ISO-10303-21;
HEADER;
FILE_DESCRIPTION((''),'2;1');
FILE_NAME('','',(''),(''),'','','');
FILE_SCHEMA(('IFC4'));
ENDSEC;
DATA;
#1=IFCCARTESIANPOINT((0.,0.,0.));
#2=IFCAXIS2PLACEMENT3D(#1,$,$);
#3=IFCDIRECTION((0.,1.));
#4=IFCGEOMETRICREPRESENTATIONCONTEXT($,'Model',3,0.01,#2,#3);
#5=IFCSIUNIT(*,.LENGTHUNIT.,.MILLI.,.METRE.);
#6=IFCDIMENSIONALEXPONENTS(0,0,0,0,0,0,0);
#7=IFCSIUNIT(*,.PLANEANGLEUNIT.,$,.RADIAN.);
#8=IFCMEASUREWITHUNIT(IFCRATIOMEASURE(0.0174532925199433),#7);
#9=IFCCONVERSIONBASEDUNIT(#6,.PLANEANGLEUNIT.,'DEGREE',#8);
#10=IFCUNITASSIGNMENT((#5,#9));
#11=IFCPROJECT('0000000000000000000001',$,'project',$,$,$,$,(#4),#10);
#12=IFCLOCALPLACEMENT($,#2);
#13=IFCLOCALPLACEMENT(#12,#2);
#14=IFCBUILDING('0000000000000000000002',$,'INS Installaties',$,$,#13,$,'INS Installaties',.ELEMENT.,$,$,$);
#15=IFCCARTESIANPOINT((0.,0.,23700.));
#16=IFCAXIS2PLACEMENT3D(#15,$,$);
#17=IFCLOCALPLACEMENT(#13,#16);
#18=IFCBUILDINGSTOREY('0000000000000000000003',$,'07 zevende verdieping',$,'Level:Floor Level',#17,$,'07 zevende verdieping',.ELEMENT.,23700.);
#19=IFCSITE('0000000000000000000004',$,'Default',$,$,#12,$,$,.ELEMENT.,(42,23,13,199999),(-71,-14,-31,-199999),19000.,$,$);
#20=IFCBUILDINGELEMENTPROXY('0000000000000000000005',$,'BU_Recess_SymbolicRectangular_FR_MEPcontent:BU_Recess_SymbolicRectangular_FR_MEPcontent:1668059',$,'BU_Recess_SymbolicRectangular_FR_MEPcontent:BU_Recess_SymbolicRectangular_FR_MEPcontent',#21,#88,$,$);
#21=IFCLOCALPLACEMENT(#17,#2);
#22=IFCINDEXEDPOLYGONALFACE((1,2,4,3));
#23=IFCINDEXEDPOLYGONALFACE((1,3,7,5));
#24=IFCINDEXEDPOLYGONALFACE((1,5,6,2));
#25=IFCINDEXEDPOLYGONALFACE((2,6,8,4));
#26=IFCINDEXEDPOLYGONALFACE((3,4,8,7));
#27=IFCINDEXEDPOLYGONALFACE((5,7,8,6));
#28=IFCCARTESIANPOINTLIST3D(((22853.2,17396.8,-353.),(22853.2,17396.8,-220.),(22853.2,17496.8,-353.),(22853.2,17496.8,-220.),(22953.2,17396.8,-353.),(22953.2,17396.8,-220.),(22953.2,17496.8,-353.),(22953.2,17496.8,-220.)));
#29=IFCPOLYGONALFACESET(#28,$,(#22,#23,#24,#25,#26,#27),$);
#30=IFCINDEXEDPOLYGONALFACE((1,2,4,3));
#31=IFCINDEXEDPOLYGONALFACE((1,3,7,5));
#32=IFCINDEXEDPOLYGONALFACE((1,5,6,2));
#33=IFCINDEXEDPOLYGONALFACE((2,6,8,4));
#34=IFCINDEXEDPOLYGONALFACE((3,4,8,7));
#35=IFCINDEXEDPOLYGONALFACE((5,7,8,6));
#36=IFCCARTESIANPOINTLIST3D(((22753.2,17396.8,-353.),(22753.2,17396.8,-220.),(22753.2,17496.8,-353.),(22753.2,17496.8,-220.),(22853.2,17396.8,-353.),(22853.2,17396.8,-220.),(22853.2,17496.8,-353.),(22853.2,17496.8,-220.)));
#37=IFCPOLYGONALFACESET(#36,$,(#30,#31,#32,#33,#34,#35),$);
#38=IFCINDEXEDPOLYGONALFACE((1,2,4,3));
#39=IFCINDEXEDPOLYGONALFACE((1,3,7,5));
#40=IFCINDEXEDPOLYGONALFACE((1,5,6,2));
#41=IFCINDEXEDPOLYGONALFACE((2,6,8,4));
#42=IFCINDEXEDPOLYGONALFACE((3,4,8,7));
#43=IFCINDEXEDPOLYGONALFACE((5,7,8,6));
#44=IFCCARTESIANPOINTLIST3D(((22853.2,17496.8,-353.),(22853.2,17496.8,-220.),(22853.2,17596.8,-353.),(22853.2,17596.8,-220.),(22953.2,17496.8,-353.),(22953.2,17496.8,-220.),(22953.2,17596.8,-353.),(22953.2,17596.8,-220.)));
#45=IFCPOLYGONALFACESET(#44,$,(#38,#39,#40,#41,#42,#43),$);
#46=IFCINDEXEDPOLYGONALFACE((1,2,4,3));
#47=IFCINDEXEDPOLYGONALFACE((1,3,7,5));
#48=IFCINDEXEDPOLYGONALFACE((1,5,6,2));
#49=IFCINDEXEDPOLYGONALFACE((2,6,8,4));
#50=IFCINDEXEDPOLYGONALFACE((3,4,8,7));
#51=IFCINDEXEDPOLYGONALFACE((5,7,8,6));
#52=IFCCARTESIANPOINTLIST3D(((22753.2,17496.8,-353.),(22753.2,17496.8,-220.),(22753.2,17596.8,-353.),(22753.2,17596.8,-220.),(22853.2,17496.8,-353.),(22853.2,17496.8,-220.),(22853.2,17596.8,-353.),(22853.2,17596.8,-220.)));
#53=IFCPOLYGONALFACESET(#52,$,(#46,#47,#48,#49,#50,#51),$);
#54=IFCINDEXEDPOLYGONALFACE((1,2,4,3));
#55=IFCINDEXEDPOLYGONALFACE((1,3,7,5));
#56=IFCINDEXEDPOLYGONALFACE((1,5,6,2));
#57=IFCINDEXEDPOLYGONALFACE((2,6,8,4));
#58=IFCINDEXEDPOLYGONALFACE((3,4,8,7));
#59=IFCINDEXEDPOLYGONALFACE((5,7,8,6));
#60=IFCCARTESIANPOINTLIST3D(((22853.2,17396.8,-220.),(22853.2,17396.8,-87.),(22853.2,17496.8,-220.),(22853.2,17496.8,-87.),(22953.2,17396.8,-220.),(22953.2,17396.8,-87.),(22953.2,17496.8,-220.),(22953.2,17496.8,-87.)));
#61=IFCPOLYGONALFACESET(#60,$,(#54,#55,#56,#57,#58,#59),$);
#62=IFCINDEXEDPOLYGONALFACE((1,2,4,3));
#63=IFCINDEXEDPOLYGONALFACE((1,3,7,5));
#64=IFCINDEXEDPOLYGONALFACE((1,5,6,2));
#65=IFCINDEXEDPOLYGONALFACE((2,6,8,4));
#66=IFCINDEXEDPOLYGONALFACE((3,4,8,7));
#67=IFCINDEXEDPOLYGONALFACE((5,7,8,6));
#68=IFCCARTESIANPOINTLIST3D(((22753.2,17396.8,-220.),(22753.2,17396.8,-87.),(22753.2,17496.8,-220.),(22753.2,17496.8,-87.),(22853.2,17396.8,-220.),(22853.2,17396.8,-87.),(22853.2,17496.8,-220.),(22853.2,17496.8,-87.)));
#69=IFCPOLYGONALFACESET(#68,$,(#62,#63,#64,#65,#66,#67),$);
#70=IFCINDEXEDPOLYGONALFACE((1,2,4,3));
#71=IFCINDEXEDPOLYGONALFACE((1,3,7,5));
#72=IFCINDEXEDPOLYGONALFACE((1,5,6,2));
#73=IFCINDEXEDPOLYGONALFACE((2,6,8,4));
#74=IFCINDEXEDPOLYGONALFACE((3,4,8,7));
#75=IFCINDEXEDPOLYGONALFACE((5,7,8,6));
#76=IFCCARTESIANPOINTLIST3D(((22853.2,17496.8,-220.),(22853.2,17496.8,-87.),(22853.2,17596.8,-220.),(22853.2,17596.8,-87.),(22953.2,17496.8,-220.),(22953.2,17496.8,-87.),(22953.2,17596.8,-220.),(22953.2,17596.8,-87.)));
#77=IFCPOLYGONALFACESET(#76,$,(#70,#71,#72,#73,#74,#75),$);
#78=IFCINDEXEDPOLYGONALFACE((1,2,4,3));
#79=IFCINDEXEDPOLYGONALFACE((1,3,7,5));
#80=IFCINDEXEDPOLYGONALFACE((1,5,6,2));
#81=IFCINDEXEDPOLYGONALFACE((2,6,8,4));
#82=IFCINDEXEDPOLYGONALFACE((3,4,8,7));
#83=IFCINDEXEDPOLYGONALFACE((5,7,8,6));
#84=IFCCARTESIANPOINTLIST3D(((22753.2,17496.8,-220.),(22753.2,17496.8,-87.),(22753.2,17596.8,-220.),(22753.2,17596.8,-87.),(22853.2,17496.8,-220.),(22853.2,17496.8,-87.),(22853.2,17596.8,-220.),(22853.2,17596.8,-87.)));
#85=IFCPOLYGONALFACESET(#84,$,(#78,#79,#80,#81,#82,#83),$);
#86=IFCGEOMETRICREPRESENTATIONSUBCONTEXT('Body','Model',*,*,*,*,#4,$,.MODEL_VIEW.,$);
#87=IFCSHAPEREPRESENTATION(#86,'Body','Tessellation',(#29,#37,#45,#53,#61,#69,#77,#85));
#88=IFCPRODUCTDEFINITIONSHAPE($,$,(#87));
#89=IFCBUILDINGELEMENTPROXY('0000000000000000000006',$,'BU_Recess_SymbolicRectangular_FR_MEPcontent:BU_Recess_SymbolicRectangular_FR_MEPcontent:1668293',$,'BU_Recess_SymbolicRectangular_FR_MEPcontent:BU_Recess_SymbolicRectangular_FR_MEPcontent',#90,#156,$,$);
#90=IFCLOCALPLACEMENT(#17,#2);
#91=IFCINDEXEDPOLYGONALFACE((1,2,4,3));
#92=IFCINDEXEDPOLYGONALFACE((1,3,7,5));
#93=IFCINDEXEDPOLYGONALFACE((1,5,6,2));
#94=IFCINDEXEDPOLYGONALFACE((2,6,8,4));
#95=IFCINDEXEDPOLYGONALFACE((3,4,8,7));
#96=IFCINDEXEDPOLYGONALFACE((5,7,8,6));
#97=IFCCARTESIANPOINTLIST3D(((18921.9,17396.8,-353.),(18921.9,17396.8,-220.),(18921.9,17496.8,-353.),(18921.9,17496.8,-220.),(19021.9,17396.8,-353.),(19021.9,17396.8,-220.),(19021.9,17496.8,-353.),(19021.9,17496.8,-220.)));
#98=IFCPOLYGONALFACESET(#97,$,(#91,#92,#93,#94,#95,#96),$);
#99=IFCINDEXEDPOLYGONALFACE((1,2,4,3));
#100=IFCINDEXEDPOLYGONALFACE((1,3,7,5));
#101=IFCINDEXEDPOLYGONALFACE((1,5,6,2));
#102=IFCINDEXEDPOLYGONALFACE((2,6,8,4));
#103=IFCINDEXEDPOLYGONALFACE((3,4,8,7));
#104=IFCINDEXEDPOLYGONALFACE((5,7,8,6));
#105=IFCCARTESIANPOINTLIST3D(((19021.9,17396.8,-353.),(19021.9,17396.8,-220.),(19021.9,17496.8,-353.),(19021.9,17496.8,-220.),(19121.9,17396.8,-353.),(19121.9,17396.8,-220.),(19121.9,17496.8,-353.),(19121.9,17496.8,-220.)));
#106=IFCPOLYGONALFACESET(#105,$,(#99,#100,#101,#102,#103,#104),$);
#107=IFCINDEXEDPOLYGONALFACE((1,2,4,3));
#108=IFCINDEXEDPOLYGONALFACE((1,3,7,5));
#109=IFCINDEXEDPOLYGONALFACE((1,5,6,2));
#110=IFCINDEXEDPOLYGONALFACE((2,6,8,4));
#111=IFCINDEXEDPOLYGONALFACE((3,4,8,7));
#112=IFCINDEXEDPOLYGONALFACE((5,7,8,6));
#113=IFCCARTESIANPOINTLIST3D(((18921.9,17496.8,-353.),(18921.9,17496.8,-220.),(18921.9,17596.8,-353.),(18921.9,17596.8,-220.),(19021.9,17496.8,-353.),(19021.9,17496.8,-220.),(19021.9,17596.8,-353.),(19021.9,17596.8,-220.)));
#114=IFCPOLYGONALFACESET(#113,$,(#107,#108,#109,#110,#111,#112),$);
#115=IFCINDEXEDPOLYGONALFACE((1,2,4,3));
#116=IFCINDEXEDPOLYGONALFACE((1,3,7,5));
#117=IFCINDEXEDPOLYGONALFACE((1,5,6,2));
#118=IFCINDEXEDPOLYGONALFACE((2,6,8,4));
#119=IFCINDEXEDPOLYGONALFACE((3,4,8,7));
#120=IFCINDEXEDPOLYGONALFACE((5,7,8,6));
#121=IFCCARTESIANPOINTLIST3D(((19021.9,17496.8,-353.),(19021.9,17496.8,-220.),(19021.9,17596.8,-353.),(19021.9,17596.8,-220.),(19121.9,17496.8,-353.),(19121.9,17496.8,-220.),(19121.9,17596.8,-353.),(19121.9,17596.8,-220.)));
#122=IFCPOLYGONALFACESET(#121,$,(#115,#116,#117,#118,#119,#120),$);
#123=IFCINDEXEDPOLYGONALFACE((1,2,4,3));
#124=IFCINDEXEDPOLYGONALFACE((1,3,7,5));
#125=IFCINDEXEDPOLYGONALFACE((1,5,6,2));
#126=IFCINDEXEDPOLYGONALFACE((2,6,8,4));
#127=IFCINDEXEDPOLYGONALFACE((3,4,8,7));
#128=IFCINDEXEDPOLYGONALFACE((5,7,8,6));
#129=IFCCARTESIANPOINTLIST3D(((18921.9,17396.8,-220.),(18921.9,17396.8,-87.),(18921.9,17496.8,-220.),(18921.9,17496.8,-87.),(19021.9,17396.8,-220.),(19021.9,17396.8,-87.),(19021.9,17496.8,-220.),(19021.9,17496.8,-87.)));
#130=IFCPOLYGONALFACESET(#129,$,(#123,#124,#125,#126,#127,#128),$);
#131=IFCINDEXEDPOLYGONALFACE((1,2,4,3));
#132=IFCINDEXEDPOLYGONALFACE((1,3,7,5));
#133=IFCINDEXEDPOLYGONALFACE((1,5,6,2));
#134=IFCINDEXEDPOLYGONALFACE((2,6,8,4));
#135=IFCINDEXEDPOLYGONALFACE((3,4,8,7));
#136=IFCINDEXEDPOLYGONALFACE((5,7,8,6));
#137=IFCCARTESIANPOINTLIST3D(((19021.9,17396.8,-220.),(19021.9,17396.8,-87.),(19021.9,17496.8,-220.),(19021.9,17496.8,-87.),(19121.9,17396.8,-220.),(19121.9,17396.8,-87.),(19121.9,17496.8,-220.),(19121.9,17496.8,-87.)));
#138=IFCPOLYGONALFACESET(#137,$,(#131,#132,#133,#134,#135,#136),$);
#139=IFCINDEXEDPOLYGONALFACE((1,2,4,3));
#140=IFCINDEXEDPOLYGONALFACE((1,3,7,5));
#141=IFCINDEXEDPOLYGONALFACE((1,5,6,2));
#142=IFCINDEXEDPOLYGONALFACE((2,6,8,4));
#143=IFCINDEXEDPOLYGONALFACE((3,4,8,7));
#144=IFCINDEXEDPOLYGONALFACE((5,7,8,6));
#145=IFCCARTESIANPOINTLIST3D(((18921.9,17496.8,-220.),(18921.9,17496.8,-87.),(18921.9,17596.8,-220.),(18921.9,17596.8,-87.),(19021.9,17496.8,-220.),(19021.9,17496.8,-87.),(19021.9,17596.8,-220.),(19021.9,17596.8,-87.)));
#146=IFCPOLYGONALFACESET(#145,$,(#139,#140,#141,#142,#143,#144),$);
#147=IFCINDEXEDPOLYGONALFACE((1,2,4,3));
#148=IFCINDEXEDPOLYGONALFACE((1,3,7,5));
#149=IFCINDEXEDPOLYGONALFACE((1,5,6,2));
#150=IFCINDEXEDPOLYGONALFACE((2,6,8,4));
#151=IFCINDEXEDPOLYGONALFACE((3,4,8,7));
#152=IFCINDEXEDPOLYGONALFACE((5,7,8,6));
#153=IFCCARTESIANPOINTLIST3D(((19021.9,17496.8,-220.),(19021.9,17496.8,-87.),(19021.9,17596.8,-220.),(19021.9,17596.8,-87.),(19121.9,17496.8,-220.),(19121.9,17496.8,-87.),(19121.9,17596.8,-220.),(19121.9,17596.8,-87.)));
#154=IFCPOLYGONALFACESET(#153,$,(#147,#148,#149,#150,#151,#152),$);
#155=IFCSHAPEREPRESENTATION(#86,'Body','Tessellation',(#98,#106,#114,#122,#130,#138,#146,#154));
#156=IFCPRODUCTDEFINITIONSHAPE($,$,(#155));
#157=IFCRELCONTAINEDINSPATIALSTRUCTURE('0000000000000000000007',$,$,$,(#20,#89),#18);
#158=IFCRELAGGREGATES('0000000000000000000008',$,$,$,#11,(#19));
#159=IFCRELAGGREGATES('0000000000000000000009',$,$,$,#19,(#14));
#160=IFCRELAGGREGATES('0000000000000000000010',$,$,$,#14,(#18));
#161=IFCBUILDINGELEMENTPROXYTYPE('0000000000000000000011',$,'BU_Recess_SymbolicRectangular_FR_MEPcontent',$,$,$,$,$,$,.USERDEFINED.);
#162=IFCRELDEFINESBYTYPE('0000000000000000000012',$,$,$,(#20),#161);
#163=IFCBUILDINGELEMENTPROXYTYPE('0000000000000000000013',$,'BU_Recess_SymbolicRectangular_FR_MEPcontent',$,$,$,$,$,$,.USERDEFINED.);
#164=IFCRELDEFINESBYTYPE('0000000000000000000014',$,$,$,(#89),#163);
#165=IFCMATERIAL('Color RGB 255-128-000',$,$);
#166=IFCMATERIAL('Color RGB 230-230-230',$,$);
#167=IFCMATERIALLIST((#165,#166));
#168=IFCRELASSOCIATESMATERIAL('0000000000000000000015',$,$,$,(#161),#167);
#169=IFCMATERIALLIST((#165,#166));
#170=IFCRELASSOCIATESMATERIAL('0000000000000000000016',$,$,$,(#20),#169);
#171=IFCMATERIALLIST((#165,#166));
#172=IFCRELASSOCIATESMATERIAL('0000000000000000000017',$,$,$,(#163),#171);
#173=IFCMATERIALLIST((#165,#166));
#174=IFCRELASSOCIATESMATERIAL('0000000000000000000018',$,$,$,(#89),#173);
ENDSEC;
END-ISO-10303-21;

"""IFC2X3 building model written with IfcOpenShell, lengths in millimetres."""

from ifc_helpers import new_model, entity, si_unit, converted_unit, direction, frame, frame_2d, origin, origin_2d_with_axis, place, context, subcontext, project, spatial, rectangle, extrude, source, transform, mapped, material, material_list, type_object, type_shapes, element, save


model = new_model("IFC2X3")

# Units and contexts
model_context = context("Model", 3, precision=0.01, world=origin(), true_north=direction((0.0, 1.0)))
body_context = subcontext(model_context, "Body", "Model", "MODEL_VIEW")
ifc_project = project(units=[si_unit("LENGTHUNIT", "METRE", prefix="MILLI"), converted_unit("PLANEANGLEUNIT", "DEGREE", entity("IfcRatioMeasure", 0.0174532925199433), si_unit("PLANEANGLEUNIT", "RADIAN"), dimensions=[0, 0, 0, 0, 0, 0, 0])], contexts=[model_context])

# Site, building, storey
site_placement = place(None, origin())
site = spatial("IfcSite", under=ifc_project, at=site_placement, Name="Default", CompositionType="ELEMENT", RefLatitude=(42, 23, 13, 199999), RefLongitude=(-71, -14, -31, -199999), RefElevation=19000.0)
building_placement = place(site_placement, origin())
building = spatial("IfcBuilding", under=site, at=building_placement, Name="INS Installaties", LongName="INS Installaties", CompositionType="ELEMENT")
storey_placement = place(building_placement, frame((0.0, 0.0, 23700.0)))
storey = spatial("IfcBuildingStorey", under=building, at=storey_placement, Name="07 zevende verdieping", ObjectType="Level:Floor Level", LongName="07 zevende verdieping", CompositionType="ELEMENT", Elevation=23700.0)

# Building element proxies
ifc_material_1 = material(Name="Color RGB 255-128-000")
ifc_material_2 = material(Name="Color RGB 230-230-230")
ifc_material_list_1 = material_list([ifc_material_1, ifc_material_2])
ifc_material_list_2 = material_list([ifc_material_1, ifc_material_2])
building_element_proxy_type_1 = type_object("IfcBuildingElementProxyType", Name="BU_Recess_SymbolicRectangular_FR_MEPcontent", PredefinedType="USERDEFINED", material=ifc_material_list_2)
shared_shape_1 = source(origin(), body_context, "Body", "SweptSolid", [
    extrude(rectangle(XDim=100.0, YDim=100.0, at=origin_2d_with_axis()), frame((50.0, -50.0, -263.0)), (0.0, 0.0, 1.0), 133.0),
    extrude(rectangle(XDim=100.0, YDim=100.0, at=origin_2d_with_axis()), frame((-50.0, -50.0, -263.0), z_axis=(0.0, 0.0, 1.0), x_axis=(0.0, 1.0, 0.0)), (0.0, 0.0, 1.0), 133.0),
    extrude(rectangle(XDim=100.0, YDim=100.0, at=frame_2d((0.0, 0.0), x_axis=(1.0, 0.0))), frame((50.0, 50.0, -263.0), z_axis=(0.0, 0.0, 1.0), x_axis=(0.0, -1.0, 0.0)), (0.0, 0.0, 1.0), 133.0),
    extrude(rectangle(XDim=100.0, YDim=100.0, at=origin_2d_with_axis()), frame((-50.0, 50.0, -263.0), z_axis=(0.0, 0.0, 1.0), x_axis=(-1.0, 0.0, 0.0)), (0.0, 0.0, 1.0), 133.0),
    extrude(rectangle(XDim=100.0, YDim=100.0, at=origin_2d_with_axis()), frame((50.0, -50.0, -130.0)), (0.0, 0.0, 1.0), 133.0),
    extrude(rectangle(XDim=100.0, YDim=100.0, at=frame_2d((0.0, 0.0), x_axis=(1.0, 0.0))), frame((-50.0, -50.0, -130.0), z_axis=(0.0, 0.0, 1.0), x_axis=(0.0, 1.0, 0.0)), (0.0, 0.0, 1.0), 133.0),
    extrude(rectangle(XDim=100.0, YDim=100.0, at=frame_2d((0.0, 0.0), x_axis=(1.0, 0.0))), frame((50.0, 50.0, -130.0), z_axis=(0.0, 0.0, 1.0), x_axis=(0.0, -1.0, 0.0)), (0.0, 0.0, 1.0), 133.0),
    extrude(rectangle(XDim=100.0, YDim=100.0, at=origin_2d_with_axis()), frame((-50.0, 50.0, -130.0), z_axis=(0.0, 0.0, 1.0), x_axis=(-1.0, 0.0, 0.0)), (0.0, 0.0, 1.0), 133.0),
])
type_shapes(building_element_proxy_type_1, [shared_shape_1])
proxy_1_placement = place(storey_placement, frame((22853.2, 17496.8, -90.0)))
element("IfcBuildingElementProxy", 1, at=proxy_1_placement, inside=storey, type_object=building_element_proxy_type_1, material=ifc_material_list_1, Name="BU_Recess_SymbolicRectangular_FR_MEPcontent:BU_Recess_SymbolicRectangular_FR_MEPcontent:1668059", ObjectType="BU_Recess_SymbolicRectangular_FR_MEPcontent:BU_Recess_SymbolicRectangular_FR_MEPcontent", context=body_context, shape_type="MappedRepresentation", body=[
    mapped(shared_shape_1, transform((0.0, 0.0, 0.0), scale=1.0)),
])
ifc_material_list_3 = material_list([ifc_material_1, ifc_material_2])
ifc_material_list_4 = material_list([ifc_material_1, ifc_material_2])
building_element_proxy_type_2 = type_object("IfcBuildingElementProxyType", Name="BU_Recess_SymbolicRectangular_FR_MEPcontent", PredefinedType="USERDEFINED", material=ifc_material_list_4)
shared_shape_2 = source(origin(), body_context, "Body", "SweptSolid", [
    extrude(rectangle(XDim=100.0, YDim=100.0, at=origin_2d_with_axis()), frame((50.0, 50.0, -263.0), z_axis=(0.0, 0.0, 1.0), x_axis=(0.0, -1.0, 0.0)), (0.0, 0.0, 1.0), 133.0),
    extrude(rectangle(XDim=100.0, YDim=100.0, at=origin_2d_with_axis()), frame((-50.0, 50.0, -263.0), z_axis=(0.0, 0.0, 1.0), x_axis=(-1.0, 0.0, 0.0)), (0.0, 0.0, 1.0), 133.0),
    extrude(rectangle(XDim=100.0, YDim=100.0, at=origin_2d_with_axis()), frame((50.0, -50.0, -263.0)), (0.0, 0.0, 1.0), 133.0),
    extrude(rectangle(XDim=100.0, YDim=100.0, at=origin_2d_with_axis()), frame((-50.0, -50.0, -263.0), z_axis=(0.0, 0.0, 1.0), x_axis=(0.0, 1.0, 0.0)), (0.0, 0.0, 1.0), 133.0),
    extrude(rectangle(XDim=100.0, YDim=100.0, at=origin_2d_with_axis()), frame((50.0, 50.0, -130.0), z_axis=(0.0, 0.0, 1.0), x_axis=(0.0, -1.0, 0.0)), (0.0, 0.0, 1.0), 133.0),
    extrude(rectangle(XDim=100.0, YDim=100.0, at=frame_2d((0.0, 0.0), x_axis=(1.0, 0.0))), frame((-50.0, 50.0, -130.0), z_axis=(0.0, 0.0, 1.0), x_axis=(-1.0, 0.0, 0.0)), (0.0, 0.0, 1.0), 133.0),
    extrude(rectangle(XDim=100.0, YDim=100.0, at=frame_2d((0.0, 0.0), x_axis=(1.0, 0.0))), frame((50.0, -50.0, -130.0)), (0.0, 0.0, 1.0), 133.0),
    extrude(rectangle(XDim=100.0, YDim=100.0, at=origin_2d_with_axis()), frame((-50.0, -50.0, -130.0), z_axis=(0.0, 0.0, 1.0), x_axis=(0.0, 1.0, 0.0)), (0.0, 0.0, 1.0), 133.0),
])
type_shapes(building_element_proxy_type_2, [shared_shape_2])
proxy_2_placement = place(storey_placement, frame((19021.9, 17496.8, -90.0), z_axis=(0.0, 0.0, 1.0), x_axis=(-1.0, 0.0, 0.0)))
element("IfcBuildingElementProxy", 2, at=proxy_2_placement, inside=storey, type_object=building_element_proxy_type_2, material=ifc_material_list_3, Name="BU_Recess_SymbolicRectangular_FR_MEPcontent:BU_Recess_SymbolicRectangular_FR_MEPcontent:1668293", ObjectType="BU_Recess_SymbolicRectangular_FR_MEPcontent:BU_Recess_SymbolicRectangular_FR_MEPcontent", context=body_context, shape_type="MappedRepresentation", body=[
    mapped(shared_shape_2, transform((0.0, 0.0, 0.0), scale=1.0)),
])

save(model, "model.ifc")
